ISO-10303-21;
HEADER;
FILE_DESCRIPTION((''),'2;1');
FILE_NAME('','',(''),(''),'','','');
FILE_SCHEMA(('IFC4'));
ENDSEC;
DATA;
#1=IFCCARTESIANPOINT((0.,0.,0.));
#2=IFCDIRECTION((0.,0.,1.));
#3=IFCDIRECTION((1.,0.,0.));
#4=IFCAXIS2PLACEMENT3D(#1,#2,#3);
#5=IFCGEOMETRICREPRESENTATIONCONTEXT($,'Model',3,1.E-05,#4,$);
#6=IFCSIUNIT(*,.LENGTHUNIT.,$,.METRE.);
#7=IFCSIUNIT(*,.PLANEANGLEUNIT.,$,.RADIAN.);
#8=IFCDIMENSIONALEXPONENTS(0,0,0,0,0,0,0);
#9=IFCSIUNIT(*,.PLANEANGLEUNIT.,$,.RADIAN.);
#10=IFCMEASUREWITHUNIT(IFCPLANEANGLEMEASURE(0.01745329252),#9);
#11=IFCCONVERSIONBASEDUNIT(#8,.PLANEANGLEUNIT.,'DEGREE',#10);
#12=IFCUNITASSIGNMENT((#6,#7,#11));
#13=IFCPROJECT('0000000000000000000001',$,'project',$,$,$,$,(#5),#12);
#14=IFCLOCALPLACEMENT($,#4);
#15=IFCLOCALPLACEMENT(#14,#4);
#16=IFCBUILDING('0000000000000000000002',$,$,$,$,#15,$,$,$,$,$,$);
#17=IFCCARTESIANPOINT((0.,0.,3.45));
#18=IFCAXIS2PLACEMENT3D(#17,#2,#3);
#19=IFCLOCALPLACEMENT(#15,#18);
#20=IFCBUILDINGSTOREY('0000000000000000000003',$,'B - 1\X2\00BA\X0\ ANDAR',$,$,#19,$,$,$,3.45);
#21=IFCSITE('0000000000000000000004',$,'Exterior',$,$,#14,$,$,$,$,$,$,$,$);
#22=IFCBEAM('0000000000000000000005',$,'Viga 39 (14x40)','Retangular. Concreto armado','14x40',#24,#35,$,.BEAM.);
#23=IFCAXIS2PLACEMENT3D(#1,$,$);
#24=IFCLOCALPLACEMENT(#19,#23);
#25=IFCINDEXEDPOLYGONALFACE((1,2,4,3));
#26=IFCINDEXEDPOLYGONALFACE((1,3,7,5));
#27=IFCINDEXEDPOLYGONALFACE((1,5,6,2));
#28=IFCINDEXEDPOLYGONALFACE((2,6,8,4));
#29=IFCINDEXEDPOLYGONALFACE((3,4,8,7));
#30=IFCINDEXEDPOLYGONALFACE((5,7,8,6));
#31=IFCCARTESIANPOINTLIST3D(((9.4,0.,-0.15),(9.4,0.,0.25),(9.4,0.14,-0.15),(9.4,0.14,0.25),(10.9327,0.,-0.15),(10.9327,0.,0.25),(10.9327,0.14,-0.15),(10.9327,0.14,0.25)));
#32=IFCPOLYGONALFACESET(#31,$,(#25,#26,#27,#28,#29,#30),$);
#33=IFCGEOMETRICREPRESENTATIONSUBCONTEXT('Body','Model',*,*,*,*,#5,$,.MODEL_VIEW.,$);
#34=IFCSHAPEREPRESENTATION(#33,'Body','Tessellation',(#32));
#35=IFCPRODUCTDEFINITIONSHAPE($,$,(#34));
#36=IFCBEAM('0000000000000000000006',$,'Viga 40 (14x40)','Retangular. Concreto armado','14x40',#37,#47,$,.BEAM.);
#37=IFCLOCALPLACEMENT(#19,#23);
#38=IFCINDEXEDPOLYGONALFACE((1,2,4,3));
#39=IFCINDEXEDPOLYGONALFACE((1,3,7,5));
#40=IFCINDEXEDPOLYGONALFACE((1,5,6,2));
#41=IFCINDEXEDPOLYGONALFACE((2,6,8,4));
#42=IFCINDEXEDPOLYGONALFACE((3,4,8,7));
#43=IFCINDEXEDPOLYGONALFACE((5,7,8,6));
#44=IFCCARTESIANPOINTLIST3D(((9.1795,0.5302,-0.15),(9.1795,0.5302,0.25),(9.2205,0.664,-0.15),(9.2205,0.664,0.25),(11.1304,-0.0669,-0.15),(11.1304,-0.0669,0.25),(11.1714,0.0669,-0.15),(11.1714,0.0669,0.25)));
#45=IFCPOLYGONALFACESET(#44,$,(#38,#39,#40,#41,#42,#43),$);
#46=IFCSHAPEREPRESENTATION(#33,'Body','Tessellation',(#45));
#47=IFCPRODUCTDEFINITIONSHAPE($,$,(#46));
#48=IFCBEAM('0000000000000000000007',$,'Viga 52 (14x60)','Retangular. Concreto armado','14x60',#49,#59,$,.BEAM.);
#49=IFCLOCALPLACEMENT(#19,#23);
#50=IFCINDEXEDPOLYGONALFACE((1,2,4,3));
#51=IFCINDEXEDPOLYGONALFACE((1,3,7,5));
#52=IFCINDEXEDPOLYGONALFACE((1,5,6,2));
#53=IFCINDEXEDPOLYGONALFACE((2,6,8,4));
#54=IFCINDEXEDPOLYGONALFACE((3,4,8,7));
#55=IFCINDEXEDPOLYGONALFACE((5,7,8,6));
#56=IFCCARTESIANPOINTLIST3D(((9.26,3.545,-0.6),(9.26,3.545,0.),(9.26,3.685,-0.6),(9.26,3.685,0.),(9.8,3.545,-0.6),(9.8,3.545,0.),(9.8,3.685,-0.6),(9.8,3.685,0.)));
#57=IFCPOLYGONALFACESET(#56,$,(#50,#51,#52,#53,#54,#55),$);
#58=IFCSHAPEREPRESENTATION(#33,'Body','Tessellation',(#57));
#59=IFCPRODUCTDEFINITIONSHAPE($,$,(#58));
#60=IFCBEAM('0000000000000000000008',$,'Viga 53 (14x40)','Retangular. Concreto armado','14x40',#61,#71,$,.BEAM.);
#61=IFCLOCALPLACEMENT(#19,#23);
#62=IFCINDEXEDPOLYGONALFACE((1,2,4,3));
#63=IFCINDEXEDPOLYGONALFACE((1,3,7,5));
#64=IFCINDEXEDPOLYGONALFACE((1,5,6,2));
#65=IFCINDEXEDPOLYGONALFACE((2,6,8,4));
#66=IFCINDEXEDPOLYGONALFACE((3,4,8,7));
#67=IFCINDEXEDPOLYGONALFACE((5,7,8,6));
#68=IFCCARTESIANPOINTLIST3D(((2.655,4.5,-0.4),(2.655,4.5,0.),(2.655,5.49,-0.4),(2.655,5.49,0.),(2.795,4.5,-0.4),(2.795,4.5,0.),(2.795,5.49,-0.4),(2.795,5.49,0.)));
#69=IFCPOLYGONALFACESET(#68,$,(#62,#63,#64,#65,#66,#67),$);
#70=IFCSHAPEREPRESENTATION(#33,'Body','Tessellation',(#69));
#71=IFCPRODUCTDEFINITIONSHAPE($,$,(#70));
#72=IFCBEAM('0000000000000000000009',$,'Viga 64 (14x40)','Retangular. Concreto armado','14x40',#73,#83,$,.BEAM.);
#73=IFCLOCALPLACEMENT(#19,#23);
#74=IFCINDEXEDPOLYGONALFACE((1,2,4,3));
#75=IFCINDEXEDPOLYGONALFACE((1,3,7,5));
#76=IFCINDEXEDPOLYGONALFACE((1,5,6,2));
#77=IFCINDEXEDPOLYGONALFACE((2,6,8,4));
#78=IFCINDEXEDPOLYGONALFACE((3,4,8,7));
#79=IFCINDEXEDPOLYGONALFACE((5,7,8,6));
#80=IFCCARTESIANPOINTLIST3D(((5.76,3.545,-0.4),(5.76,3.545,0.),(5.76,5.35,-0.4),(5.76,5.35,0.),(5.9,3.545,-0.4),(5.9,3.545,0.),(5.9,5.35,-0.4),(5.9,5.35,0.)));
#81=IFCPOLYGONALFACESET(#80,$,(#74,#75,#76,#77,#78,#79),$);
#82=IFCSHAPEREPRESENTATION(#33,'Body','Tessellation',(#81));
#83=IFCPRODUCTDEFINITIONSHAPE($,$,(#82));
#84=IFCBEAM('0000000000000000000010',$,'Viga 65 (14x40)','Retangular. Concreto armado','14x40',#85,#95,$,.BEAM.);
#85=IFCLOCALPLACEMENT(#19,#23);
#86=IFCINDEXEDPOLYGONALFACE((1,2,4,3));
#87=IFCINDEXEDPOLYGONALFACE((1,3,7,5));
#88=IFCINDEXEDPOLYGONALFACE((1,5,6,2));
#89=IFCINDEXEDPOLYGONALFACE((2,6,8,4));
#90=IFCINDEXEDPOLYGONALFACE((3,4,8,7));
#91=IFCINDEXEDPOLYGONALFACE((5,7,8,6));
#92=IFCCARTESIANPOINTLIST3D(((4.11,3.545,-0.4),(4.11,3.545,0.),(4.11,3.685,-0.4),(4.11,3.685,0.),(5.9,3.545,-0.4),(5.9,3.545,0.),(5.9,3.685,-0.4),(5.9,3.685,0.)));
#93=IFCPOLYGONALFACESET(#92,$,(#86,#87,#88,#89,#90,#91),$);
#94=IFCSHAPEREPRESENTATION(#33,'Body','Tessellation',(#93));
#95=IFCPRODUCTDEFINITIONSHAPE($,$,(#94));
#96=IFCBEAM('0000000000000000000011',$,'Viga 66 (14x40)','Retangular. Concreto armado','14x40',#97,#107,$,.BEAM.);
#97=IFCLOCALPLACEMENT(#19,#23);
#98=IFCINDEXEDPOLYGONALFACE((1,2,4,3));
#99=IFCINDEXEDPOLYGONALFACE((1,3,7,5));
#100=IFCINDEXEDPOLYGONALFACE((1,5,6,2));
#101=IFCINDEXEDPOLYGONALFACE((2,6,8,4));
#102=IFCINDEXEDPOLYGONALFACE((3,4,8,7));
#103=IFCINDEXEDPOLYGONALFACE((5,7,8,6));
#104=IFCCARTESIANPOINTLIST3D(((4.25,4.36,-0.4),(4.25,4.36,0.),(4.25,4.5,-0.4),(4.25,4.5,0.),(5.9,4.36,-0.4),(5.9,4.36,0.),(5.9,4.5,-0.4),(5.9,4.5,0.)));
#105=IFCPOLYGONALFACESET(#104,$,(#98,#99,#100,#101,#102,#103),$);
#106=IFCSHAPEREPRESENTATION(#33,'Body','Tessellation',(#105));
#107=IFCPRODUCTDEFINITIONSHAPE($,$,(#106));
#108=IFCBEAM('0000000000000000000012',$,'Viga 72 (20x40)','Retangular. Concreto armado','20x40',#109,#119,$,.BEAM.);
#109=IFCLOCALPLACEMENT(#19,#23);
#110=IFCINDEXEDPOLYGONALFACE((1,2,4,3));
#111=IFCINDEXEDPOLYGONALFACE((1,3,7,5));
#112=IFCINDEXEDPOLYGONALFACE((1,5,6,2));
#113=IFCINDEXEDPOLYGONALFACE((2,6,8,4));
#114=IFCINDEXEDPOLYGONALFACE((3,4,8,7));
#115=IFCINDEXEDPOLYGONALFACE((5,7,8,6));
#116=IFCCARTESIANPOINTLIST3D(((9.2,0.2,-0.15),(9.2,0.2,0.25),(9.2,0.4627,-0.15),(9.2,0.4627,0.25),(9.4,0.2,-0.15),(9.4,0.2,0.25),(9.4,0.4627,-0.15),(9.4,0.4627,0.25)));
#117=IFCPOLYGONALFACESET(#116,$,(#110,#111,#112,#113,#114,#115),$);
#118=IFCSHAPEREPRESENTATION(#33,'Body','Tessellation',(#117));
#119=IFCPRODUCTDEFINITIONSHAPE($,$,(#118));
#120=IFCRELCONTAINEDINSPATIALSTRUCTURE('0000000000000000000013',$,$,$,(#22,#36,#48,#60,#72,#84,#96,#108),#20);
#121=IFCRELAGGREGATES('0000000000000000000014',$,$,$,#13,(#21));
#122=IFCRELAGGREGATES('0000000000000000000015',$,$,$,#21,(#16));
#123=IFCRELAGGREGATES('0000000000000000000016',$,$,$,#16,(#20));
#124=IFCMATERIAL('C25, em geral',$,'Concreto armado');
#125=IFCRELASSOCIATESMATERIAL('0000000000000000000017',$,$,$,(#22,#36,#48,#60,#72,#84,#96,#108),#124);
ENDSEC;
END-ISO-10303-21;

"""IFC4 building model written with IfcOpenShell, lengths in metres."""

from ifc_helpers import new_model, entity, si_unit, converted_unit, frame, frame_2d, origin_with_axes, place, context, subcontext, project, spatial, rectangle, extrude, material, element, save


model = new_model("IFC4")

# Units and contexts
model_context = context("Model", 3, precision=1e-05, world=origin_with_axes())
body_context = subcontext(model_context, "Body", "Model", "MODEL_VIEW")
ifc_project = project(units=[si_unit("LENGTHUNIT", "METRE"), si_unit("PLANEANGLEUNIT", "RADIAN"), converted_unit("PLANEANGLEUNIT", "DEGREE", entity("IfcPlaneAngleMeasure", 0.01745329252), si_unit("PLANEANGLEUNIT", "RADIAN"), dimensions=[0, 0, 0, 0, 0, 0, 0])], contexts=[model_context])

# Site, building, storey
site_placement = place(None, origin_with_axes())
site = spatial("IfcSite", under=ifc_project, at=site_placement, Name="Exterior")
building_placement = place(site_placement, origin_with_axes())
building = spatial("IfcBuilding", under=site, at=building_placement)
storey_placement = place(building_placement, frame((0.0, 0.0, 3.45), z_axis=(0.0, 0.0, 1.0), x_axis=(1.0, 0.0, 0.0)))
storey = spatial("IfcBuildingStorey", under=building, at=storey_placement, Name="B - 1º ANDAR", Elevation=3.45)

# Shared definitions
ifc_material = material(Name="C25, em geral", Category="Concreto armado")

# Beams
beam_1_placement = place(storey_placement, frame((9.4, 0.07, 0.25), z_axis=(1.0, 0.0, 0.0), x_axis=(0.0, 1.0, 0.0)))
element("IfcBeam", 1, at=beam_1_placement, inside=storey, material=ifc_material, Name="Viga 39 (14x40)", Description="Retangular. Concreto armado", ObjectType="14x40", PredefinedType="BEAM", context=body_context, shape_type="SweptSolid", body=[
    extrude(rectangle(XDim=0.14, YDim=0.4, at=frame_2d((0.0, -0.2), x_axis=(1.0, 0.0))), origin_with_axes(), (0.0, 0.0, 1.0), 1.5327),
])
beam_2_placement = place(storey_placement, frame((11.1509, 0.0, 0.25), z_axis=(-0.956217, 0.29266, 0.0), x_axis=(-0.29266, -0.956217, 0.0)))
element("IfcBeam", 2, at=beam_2_placement, inside=storey, material=ifc_material, Name="Viga 40 (14x40)", Description="Retangular. Concreto armado", ObjectType="14x40", PredefinedType="BEAM", context=body_context, shape_type="SweptSolid", body=[
    extrude(rectangle(XDim=0.14, YDim=0.4, at=frame_2d((0.0, -0.2), x_axis=(1.0, 0.0))), origin_with_axes(), (0.0, 0.0, 1.0), 2.0402),
])
beam_3_placement = place(storey_placement, frame((9.8, 3.615, 0.0), z_axis=(-1.0, 0.0, 0.0), x_axis=(0.0, -1.0, 0.0)))
element("IfcBeam", 3, at=beam_3_placement, inside=storey, material=ifc_material, Name="Viga 52 (14x60)", Description="Retangular. Concreto armado", ObjectType="14x60", PredefinedType="BEAM", context=body_context, shape_type="SweptSolid", body=[
    extrude(rectangle(XDim=0.14, YDim=0.6, at=frame_2d((0.0, -0.3), x_axis=(1.0, 0.0))), origin_with_axes(), (0.0, 0.0, 1.0), 0.54),
])
beam_4_placement = place(storey_placement, frame((2.725, 4.5, 0.0), z_axis=(0.0, 1.0, 0.0), x_axis=(-1.0, 0.0, 0.0)))
element("IfcBeam", 4, at=beam_4_placement, inside=storey, material=ifc_material, Name="Viga 53 (14x40)", Description="Retangular. Concreto armado", ObjectType="14x40", PredefinedType="BEAM", context=body_context, shape_type="SweptSolid", body=[
    extrude(rectangle(XDim=0.14, YDim=0.4, at=frame_2d((0.0, -0.2), x_axis=(1.0, 0.0))), origin_with_axes(), (0.0, 0.0, 1.0), 0.99),
])
beam_5_placement = place(storey_placement, frame((5.83, 3.545, 0.0), z_axis=(0.0, 1.0, 0.0), x_axis=(-1.0, 0.0, 0.0)))
element("IfcBeam", 5, at=beam_5_placement, inside=storey, material=ifc_material, Name="Viga 64 (14x40)", Description="Retangular. Concreto armado", ObjectType="14x40", PredefinedType="BEAM", context=body_context, shape_type="SweptSolid", body=[
    extrude(rectangle(XDim=0.14, YDim=0.4, at=frame_2d((0.0, -0.2), x_axis=(1.0, 0.0))), origin_with_axes(), (0.0, 0.0, 1.0), 1.805),
])
beam_6_placement = place(storey_placement, frame((4.11, 3.615, 0.0), z_axis=(1.0, 0.0, 0.0), x_axis=(0.0, 1.0, 0.0)))
element("IfcBeam", 6, at=beam_6_placement, inside=storey, material=ifc_material, Name="Viga 65 (14x40)", Description="Retangular. Concreto armado", ObjectType="14x40", PredefinedType="BEAM", context=body_context, shape_type="SweptSolid", body=[
    extrude(rectangle(XDim=0.14, YDim=0.4, at=frame_2d((0.0, -0.2), x_axis=(1.0, 0.0))), origin_with_axes(), (0.0, 0.0, 1.0), 1.79),
])
beam_7_placement = place(storey_placement, frame((4.25, 4.43, 0.0), z_axis=(1.0, 0.0, 0.0), x_axis=(0.0, 1.0, 0.0)))
element("IfcBeam", 7, at=beam_7_placement, inside=storey, material=ifc_material, Name="Viga 66 (14x40)", Description="Retangular. Concreto armado", ObjectType="14x40", PredefinedType="BEAM", context=body_context, shape_type="SweptSolid", body=[
    extrude(rectangle(XDim=0.14, YDim=0.4, at=frame_2d((0.0, -0.2), x_axis=(1.0, 0.0))), origin_with_axes(), (0.0, 0.0, 1.0), 1.65),
])
beam_8_placement = place(storey_placement, frame((9.3, 0.4627, 0.25), z_axis=(0.0, -1.0, 0.0), x_axis=(1.0, 0.0, 0.0)))
element("IfcBeam", 8, at=beam_8_placement, inside=storey, material=ifc_material, Name="Viga 72 (20x40)", Description="Retangular. Concreto armado", ObjectType="20x40", PredefinedType="BEAM", context=body_context, shape_type="SweptSolid", body=[
    extrude(rectangle(XDim=0.2, YDim=0.4, at=frame_2d((0.0, -0.2), x_axis=(1.0, 0.0))), origin_with_axes(), (0.0, 0.0, 1.0), 0.2627),
])

save(model, "model.ifc")
